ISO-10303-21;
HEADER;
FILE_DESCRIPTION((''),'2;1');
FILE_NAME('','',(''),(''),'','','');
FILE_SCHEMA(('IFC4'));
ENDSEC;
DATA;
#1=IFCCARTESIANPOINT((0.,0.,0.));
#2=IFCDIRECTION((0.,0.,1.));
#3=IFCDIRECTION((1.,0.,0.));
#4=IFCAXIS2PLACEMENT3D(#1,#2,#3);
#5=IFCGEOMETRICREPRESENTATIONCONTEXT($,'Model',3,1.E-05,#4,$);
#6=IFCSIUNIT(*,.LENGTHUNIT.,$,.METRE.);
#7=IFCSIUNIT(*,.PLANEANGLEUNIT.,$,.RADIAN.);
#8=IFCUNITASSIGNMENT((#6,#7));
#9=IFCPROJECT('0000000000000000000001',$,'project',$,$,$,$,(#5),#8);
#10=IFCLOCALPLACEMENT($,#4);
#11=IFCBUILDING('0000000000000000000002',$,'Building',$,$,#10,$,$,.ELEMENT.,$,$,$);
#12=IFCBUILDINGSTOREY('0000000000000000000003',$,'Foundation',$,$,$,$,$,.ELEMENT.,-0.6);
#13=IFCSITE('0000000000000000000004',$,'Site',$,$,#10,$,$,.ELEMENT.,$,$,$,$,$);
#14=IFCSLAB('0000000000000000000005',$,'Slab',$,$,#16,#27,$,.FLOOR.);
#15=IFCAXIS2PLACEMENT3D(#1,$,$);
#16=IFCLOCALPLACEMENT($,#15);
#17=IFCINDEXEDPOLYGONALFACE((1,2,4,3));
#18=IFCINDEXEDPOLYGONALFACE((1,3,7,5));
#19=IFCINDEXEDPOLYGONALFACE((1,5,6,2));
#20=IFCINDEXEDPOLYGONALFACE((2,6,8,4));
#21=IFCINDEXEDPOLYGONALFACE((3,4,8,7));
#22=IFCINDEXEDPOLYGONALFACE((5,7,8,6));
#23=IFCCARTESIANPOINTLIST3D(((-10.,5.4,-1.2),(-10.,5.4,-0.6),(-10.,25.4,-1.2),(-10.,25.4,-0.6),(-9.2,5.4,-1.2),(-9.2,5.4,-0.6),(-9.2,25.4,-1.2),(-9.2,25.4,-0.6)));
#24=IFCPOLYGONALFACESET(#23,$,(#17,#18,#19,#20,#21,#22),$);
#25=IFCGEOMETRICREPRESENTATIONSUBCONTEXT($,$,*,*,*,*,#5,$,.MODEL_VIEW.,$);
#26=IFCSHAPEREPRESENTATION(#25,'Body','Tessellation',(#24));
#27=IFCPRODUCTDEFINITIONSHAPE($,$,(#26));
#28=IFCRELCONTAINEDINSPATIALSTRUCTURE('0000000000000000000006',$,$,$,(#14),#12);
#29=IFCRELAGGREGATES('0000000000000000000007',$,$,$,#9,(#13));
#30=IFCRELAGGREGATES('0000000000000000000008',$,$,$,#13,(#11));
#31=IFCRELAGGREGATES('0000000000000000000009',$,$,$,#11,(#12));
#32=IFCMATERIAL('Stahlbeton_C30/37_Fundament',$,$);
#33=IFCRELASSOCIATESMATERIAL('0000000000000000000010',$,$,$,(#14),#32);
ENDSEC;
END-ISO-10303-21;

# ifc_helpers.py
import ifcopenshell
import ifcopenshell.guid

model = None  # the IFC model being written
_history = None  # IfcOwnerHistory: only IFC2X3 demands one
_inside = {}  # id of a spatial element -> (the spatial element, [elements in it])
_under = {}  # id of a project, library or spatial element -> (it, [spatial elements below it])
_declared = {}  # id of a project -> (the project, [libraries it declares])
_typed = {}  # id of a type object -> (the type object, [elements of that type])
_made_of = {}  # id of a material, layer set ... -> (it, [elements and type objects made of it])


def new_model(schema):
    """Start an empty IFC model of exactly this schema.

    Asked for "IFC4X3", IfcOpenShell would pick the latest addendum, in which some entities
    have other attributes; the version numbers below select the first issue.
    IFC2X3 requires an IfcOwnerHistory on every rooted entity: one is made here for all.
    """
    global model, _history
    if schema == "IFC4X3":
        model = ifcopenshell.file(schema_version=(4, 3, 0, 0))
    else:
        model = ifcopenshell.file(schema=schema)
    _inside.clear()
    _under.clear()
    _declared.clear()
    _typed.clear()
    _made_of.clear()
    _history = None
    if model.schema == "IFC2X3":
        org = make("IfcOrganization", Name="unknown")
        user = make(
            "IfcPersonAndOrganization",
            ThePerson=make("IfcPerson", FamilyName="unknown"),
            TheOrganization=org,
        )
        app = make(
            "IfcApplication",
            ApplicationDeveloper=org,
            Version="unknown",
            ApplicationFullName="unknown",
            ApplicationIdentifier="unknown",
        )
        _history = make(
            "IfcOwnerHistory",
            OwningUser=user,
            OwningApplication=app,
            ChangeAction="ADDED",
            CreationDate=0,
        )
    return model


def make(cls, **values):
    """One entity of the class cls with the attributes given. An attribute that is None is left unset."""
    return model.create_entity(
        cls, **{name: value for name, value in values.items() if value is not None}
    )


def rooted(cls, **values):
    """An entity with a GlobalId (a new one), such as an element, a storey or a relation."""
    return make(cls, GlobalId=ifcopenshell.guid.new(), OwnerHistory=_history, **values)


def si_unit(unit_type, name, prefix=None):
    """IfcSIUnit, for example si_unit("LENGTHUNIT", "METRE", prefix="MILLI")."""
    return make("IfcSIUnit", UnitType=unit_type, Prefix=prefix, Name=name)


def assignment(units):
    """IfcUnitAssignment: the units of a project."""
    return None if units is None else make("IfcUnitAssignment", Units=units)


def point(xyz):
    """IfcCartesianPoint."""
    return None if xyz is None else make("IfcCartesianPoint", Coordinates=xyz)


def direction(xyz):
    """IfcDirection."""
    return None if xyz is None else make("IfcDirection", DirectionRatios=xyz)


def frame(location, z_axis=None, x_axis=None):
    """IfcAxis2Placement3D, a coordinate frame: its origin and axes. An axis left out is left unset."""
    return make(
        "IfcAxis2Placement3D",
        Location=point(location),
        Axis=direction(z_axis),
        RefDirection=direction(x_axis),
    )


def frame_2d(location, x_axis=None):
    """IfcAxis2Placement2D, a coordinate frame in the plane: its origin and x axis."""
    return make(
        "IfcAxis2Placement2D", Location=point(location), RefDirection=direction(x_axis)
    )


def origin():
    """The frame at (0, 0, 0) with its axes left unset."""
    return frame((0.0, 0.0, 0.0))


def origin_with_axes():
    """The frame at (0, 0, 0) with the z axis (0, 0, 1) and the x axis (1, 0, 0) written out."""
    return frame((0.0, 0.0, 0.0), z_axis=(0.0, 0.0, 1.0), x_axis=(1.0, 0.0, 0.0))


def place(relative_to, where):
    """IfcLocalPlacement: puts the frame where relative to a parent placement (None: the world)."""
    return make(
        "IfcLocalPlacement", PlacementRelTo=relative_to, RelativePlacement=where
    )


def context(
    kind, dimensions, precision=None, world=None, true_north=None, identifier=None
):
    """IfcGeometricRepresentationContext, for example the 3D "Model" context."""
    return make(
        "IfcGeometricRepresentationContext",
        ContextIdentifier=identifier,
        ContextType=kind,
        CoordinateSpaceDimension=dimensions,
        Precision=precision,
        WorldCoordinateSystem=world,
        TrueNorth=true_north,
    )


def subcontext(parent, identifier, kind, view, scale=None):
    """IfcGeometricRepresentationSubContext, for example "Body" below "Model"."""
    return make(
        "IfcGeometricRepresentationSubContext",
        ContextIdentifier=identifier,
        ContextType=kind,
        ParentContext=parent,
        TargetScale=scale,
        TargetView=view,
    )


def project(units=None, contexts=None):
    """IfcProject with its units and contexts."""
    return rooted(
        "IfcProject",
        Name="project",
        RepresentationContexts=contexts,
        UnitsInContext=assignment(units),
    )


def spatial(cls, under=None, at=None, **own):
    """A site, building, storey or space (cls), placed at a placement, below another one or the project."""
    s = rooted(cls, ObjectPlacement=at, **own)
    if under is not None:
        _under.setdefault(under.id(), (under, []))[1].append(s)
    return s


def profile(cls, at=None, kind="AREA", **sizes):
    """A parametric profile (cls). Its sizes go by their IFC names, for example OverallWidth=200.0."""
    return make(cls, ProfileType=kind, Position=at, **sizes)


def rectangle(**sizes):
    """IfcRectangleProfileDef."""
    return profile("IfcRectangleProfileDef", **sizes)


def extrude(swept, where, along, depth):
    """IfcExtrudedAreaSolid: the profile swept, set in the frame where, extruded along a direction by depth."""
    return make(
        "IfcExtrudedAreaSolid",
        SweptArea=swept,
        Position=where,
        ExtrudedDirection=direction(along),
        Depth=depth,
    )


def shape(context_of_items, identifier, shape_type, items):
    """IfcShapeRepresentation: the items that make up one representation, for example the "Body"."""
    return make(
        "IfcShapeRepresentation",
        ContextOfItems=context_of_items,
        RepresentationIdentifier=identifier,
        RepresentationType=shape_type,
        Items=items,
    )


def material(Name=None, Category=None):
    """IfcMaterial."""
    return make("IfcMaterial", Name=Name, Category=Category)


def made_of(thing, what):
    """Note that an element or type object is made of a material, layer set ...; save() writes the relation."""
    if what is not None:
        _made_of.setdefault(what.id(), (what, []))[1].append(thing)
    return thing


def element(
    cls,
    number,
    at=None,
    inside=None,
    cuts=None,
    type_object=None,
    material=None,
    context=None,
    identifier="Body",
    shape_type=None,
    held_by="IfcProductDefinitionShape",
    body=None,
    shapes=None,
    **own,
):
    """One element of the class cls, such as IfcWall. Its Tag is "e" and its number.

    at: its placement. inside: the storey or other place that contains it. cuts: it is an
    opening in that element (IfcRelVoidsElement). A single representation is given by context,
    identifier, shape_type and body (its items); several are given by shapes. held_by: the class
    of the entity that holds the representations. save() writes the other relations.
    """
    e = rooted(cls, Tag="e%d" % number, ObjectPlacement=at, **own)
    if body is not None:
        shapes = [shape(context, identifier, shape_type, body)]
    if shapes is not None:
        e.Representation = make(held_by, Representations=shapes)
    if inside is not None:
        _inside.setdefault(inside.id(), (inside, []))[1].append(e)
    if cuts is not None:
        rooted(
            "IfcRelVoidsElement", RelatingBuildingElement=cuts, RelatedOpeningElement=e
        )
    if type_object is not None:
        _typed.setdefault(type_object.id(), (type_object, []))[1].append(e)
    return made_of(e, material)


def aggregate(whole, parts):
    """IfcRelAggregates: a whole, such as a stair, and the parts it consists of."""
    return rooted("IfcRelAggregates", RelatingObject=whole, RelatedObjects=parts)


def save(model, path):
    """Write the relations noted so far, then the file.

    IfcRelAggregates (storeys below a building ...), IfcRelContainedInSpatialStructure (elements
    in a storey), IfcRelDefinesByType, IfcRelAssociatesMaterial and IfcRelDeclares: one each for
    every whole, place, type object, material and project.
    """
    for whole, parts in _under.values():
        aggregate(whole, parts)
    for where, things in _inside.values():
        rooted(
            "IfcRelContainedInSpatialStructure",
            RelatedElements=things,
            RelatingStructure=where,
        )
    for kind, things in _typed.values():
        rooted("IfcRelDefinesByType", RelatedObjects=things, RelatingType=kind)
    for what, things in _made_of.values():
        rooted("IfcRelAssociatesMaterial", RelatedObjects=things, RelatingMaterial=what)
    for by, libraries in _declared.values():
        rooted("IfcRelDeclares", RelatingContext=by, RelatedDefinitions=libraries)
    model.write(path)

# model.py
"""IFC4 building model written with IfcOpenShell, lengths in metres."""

from ifc_helpers import new_model, si_unit, frame, frame_2d, origin, origin_with_axes, place, context, subcontext, project, spatial, rectangle, extrude, material, element, save


model = new_model("IFC4")

# Units and contexts
model_context = context("Model", 3, precision=1e-05, world=origin_with_axes())
sub_context = subcontext(model_context, None, None, "MODEL_VIEW")
ifc_project = project(units=[si_unit("LENGTHUNIT", "METRE"), si_unit("PLANEANGLEUNIT", "RADIAN")], contexts=[model_context])

# Site, building, storey
placement_1 = place(None, origin_with_axes())
site = spatial("IfcSite", under=ifc_project, at=placement_1, Name="Site", CompositionType="ELEMENT")
building = spatial("IfcBuilding", under=site, at=placement_1, Name="Building", CompositionType="ELEMENT")
storey = spatial("IfcBuildingStorey", under=building, Name="Foundation", CompositionType="ELEMENT", Elevation=-0.6)

# Slab
ifc_material = material(Name="Stahlbeton_C30/37_Fundament")
placement_2 = place(None, origin_with_axes())
placement_3 = place(placement_2, frame((0.0, 0.0, -0.6)))
slab_placement = place(placement_3, frame((-10.0, 5.4, -0.6)))
element("IfcSlab", 1, at=slab_placement, inside=storey, material=ifc_material, Name="Slab", PredefinedType="FLOOR", context=sub_context, shape_type="SweptSolid", body=[
    extrude(rectangle(XDim=0.8, YDim=20.0, at=frame_2d((0.4, 10.0))), origin(), (0.0, 0.0, 1.0), 0.6),
])

save(model, "model.ifc")
